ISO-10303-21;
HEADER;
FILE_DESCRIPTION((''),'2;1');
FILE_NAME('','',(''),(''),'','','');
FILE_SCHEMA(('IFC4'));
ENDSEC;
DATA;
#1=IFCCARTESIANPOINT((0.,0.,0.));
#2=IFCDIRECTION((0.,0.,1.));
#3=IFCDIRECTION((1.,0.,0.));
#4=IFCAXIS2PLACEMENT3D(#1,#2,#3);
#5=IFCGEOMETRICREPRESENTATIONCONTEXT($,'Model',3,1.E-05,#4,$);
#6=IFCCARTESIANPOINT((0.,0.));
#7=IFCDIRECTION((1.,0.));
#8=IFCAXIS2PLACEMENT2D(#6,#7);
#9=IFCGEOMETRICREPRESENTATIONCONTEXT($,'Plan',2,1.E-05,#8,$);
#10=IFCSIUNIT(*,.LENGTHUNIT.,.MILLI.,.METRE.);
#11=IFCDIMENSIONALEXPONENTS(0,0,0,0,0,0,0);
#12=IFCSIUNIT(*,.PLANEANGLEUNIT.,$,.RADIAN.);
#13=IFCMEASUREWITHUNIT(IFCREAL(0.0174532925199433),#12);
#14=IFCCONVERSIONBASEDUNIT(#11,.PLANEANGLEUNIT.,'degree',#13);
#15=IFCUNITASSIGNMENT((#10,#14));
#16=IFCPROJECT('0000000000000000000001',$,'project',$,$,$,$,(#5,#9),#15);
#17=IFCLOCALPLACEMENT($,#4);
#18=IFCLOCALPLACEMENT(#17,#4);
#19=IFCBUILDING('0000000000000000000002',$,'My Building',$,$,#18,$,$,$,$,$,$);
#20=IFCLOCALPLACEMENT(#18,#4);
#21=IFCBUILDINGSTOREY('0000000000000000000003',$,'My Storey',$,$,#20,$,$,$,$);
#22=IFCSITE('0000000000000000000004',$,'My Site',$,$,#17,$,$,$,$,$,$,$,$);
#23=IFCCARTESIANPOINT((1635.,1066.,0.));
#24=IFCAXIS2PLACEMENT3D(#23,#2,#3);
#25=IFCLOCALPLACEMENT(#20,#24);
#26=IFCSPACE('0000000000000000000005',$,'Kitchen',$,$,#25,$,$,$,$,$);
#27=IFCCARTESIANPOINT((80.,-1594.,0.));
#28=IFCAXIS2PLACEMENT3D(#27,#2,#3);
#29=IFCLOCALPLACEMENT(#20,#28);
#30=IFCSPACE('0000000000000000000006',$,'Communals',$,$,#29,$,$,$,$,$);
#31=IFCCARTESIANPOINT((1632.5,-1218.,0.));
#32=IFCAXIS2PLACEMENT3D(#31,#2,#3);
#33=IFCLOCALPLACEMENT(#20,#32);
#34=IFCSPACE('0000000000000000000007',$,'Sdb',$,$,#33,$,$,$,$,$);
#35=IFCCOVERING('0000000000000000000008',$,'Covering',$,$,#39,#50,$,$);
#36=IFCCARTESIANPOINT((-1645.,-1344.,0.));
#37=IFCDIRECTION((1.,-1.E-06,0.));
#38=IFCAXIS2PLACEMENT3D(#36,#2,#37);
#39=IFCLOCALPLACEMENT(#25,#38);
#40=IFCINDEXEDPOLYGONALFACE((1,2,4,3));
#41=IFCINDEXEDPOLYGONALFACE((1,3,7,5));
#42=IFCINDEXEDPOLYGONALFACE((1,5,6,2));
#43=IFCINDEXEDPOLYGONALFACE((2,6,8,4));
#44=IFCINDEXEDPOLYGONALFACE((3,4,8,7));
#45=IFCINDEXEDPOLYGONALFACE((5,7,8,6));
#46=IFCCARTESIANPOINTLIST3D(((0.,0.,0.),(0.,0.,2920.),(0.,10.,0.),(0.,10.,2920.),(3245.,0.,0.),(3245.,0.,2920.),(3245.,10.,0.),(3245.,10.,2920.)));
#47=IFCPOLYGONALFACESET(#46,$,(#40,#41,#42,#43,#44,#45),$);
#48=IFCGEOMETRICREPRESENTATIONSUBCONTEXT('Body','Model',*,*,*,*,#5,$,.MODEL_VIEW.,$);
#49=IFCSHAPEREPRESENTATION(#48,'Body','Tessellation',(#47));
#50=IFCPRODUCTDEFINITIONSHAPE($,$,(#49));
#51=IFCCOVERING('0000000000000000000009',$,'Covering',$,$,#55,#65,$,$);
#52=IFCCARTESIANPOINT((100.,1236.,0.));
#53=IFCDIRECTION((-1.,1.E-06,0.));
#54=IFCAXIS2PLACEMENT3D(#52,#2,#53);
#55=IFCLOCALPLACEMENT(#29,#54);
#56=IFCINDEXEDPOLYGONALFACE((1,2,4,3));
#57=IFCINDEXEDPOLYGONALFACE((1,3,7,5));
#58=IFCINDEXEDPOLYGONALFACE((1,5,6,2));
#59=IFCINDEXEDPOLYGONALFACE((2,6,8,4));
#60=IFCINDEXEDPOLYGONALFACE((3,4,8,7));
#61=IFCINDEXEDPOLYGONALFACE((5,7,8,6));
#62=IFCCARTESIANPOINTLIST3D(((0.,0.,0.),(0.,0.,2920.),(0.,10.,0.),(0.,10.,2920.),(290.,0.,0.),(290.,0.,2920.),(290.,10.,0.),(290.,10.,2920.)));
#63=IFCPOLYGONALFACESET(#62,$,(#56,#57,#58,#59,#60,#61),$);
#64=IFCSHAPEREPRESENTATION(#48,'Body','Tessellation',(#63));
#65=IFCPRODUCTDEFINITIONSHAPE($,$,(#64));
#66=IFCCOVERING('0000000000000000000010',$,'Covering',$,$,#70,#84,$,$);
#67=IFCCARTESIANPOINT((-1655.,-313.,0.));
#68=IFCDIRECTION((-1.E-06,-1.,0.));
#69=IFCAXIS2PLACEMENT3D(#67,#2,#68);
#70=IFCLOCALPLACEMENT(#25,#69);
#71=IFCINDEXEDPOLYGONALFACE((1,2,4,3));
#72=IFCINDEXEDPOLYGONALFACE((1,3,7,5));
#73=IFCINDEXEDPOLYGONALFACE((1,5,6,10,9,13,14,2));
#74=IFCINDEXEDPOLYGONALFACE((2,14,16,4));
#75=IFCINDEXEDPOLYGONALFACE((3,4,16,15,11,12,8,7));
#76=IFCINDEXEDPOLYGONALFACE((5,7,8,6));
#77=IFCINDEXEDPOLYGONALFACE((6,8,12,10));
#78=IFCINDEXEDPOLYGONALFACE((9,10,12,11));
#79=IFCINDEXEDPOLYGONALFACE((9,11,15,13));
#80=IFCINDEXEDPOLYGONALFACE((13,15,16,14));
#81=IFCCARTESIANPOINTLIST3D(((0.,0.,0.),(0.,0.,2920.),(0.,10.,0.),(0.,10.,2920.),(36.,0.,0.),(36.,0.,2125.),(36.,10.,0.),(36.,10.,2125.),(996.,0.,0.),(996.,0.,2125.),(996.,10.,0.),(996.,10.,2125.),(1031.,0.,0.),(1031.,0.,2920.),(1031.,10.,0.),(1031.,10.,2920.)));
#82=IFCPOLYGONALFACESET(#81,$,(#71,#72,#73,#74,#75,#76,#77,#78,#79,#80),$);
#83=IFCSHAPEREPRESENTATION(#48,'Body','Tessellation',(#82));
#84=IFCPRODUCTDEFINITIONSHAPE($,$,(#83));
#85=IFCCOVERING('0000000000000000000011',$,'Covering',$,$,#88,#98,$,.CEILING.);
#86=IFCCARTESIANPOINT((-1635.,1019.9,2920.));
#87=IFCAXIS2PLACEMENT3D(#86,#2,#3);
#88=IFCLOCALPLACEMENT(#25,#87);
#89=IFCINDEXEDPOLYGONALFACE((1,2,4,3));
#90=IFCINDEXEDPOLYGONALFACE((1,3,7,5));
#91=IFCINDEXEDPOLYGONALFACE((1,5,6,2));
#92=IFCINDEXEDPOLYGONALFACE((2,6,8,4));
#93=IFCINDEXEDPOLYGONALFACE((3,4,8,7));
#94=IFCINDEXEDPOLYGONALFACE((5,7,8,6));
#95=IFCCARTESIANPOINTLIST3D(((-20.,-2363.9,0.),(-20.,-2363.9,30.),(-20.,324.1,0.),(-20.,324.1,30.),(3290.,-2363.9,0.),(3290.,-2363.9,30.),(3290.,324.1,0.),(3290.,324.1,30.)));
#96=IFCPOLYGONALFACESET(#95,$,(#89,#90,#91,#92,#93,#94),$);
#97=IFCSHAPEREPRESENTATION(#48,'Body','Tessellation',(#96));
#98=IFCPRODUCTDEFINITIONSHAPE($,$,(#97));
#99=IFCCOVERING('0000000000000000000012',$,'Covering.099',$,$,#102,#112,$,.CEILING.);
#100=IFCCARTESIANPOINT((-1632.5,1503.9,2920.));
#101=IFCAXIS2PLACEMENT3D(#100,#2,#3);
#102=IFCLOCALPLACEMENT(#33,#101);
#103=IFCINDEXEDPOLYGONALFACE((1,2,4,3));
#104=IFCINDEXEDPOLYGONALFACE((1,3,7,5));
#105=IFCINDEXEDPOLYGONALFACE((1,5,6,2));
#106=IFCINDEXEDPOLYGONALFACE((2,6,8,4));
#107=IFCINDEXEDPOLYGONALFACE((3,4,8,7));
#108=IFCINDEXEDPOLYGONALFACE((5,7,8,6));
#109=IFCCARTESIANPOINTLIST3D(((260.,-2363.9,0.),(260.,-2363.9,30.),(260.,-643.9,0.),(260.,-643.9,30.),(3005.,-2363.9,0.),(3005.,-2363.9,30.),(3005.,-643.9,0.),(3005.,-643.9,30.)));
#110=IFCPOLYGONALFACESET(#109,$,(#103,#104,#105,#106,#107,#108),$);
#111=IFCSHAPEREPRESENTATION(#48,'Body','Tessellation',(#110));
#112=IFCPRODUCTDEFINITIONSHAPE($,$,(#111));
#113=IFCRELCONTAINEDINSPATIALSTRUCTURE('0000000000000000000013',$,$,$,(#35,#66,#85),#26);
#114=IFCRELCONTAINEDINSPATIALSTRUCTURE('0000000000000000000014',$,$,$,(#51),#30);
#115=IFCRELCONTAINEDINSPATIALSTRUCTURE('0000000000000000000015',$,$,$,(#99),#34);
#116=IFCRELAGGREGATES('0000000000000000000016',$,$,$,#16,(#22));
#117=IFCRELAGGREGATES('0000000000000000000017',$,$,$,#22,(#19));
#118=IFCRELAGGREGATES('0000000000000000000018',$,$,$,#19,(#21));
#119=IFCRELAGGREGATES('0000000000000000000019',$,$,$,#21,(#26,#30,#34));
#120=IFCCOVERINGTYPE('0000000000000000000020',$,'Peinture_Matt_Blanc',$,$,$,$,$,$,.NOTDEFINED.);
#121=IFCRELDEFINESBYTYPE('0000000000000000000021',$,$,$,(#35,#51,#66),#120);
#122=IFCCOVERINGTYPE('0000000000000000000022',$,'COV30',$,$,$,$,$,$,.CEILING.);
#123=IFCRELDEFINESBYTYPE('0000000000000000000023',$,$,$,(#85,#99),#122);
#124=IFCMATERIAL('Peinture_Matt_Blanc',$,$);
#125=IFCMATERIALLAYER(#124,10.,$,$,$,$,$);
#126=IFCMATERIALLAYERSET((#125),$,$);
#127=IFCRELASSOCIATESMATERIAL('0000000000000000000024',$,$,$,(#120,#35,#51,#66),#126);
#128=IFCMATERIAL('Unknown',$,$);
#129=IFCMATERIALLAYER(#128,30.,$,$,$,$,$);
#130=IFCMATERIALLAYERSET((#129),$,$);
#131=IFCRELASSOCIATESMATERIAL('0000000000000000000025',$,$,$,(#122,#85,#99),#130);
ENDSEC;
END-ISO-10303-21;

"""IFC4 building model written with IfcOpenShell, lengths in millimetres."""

from ifc_helpers import new_model, entity, si_unit, converted_unit, frame, origin_with_axes, origin_2d_with_axis, place, context, subcontext, project, spatial, line, indexed_curve, outline, extrude, clip, halfspace, source, transform, mapped, material, layer, layer_set, layer_usage, type_object, element, save


model = new_model("IFC4")

# Units and contexts
model_context = context("Model", 3, precision=1e-05, world=origin_with_axes())
plan_context = context("Plan", 2, precision=1e-05, world=origin_2d_with_axis())
body_context = subcontext(model_context, "Body", "Model", "MODEL_VIEW")
ifc_project = project(units=[si_unit("LENGTHUNIT", "METRE", prefix="MILLI"), converted_unit("PLANEANGLEUNIT", "degree", entity("IfcReal", 0.0174532925199433), si_unit("PLANEANGLEUNIT", "RADIAN"), dimensions=[0, 0, 0, 0, 0, 0, 0])], contexts=[model_context, plan_context])

# Site, building, storey
site_placement = place(None, origin_with_axes())
site = spatial("IfcSite", under=ifc_project, at=site_placement, Name="My Site")
building_placement = place(site_placement, origin_with_axes())
building = spatial("IfcBuilding", under=site, at=building_placement, Name="My Building")
storey_placement = place(building_placement, origin_with_axes())
storey = spatial("IfcBuildingStorey", under=building, at=storey_placement, Name="My Storey")

# Shared definitions
ifc_material_1 = material(Name="Unknown")

# Shared definitions
space_1_placement = place(storey_placement, frame((1635.0, 1066.0, 0.0), z_axis=(0.0, 0.0, 1.0), x_axis=(1.0, 0.0, 0.0)))
space_1 = spatial("IfcSpace", under=storey, at=space_1_placement, Name="Kitchen")

# Covering
ifc_material_2 = material(Name="Peinture_Matt_Blanc")
ifc_layer_1 = layer(ifc_material_2, 10.0)
ifc_layer_set_1 = layer_set([ifc_layer_1])
ifc_layer_usage_1 = layer_usage(ifc_layer_set_1, "AXIS2", "POSITIVE", 0.0)
covering_type_1 = type_object("IfcCoveringType", Name="Peinture_Matt_Blanc", PredefinedType="NOTDEFINED", material=ifc_layer_set_1)
covering_1_placement = place(space_1_placement, frame((-1645.0, -1344.0, 0.0), z_axis=(0.0, 0.0, 1.0), x_axis=(1.0, -0.000001, 0.0)))
element("IfcCovering", 1, at=covering_1_placement, inside=space_1, type_object=covering_type_1, material=ifc_layer_usage_1, Name="Covering", context=body_context, shape_type="Clipping", body=[
    clip(clip(extrude(outline(indexed_curve([(0.0, 0.0), (0.0, 10.0), (3245.0, 10.0), (3245.0, 0.0), (0.0, 0.0)], self_intersect=False)), origin_with_axes(), (0.0, 0.0, 1.0), 2920.0), halfspace(frame((0.0, 0.0, 2920.0), z_axis=(0.0, 0.0, 1.0), x_axis=(-1.0, 0.0, 0.0)), False)), halfspace(frame((0.0, 0.0, 2920.0), z_axis=(0.0, 0.0, 1.0), x_axis=(-1.0, 0.0, 0.0)), False)),
])

# Shared definitions
space_2_placement = place(storey_placement, frame((80.0, -1594.0, 0.0), z_axis=(0.0, 0.0, 1.0), x_axis=(1.0, 0.0, 0.0)))
space_2 = spatial("IfcSpace", under=storey, at=space_2_placement, Name="Communals")

# Covering
ifc_layer_usage_2 = layer_usage(ifc_layer_set_1, "AXIS2", "POSITIVE", 0.0)
covering_2_placement = place(space_2_placement, frame((100.0, 1236.0, 0.0), z_axis=(0.0, 0.0, 1.0), x_axis=(-1.0, 0.000001, 0.0)))
element("IfcCovering", 2, at=covering_2_placement, inside=space_2, type_object=covering_type_1, material=ifc_layer_usage_2, Name="Covering", context=body_context, shape_type="Clipping", body=[
    clip(clip(extrude(outline(indexed_curve([(0.0, 0.0), (0.0, 10.0), (290.0, 10.0), (290.0, 0.0), (0.0, 0.0)], self_intersect=False)), origin_with_axes(), (0.0, 0.0, 1.0), 2920.0), halfspace(frame((0.0, 0.0, 2920.0), z_axis=(0.0, 0.0, 1.0), x_axis=(-1.0, 0.0, 0.0)), False)), halfspace(frame((0.0, 0.0, 2920.0), z_axis=(0.0, 0.0, 1.0), x_axis=(-1.0, 0.0, 0.0)), False)),
])

# Covering, opening
ifc_layer_usage_3 = layer_usage(ifc_layer_set_1, "AXIS2", "POSITIVE", 0.0)
covering_3_placement = place(space_1_placement, frame((-1655.0, -313.0, 0.0), z_axis=(0.0, 0.0, 1.0), x_axis=(-0.000001, -1.0, 0.0)))
covering_3 = element("IfcCovering", 3, at=covering_3_placement, inside=space_1, type_object=covering_type_1, material=ifc_layer_usage_3, Name="Covering", context=body_context, shape_type="Clipping", body=[
    clip(clip(extrude(outline(indexed_curve([(0.0, 0.0), (0.0, 10.0), (1031.0, 10.0), (1031.0, 0.0), (0.0, 0.0)], self_intersect=False)), origin_with_axes(), (0.0, 0.0, 1.0), 2920.0), halfspace(frame((0.0, 0.0, 2920.0), z_axis=(0.0, 0.0, 1.0), x_axis=(-1.0, 0.0, 0.0)), False)), halfspace(frame((0.0, 0.0, 2920.0), z_axis=(0.0, 0.0, 1.0), x_axis=(-1.0, 0.0, 0.0)), False)),
])
shared_shape_1 = source(origin_with_axes(), body_context, "Body", "SweptSolid", [
    extrude(outline(indexed_curve([(0.0, 0.0), (960.0, 0.0), (960.0, 2125.0), (0.0, 2125.0)], segments=[line(4, 1), line(1, 2), line(2, 3), line(3, 4)], self_intersect=False)), frame((0.0, -600.0, 0.0), z_axis=(0.0, -1.0, 0.0), x_axis=(1.0, 0.0, 0.0)), (0.0, 0.0, -1.0), 1200.0),
])
opening_1_placement = place(covering_3_placement, frame((996.0, 0.0, 0.0), z_axis=(0.0, 0.0, 1.0), x_axis=(-1.0, 0.0, 0.0)))
element("IfcOpeningElement", 4, at=opening_1_placement, cuts=covering_3, PredefinedType="OPENING", context=body_context, shape_type="MappedRepresentation", body=[
    mapped(shared_shape_1, transform((0.0, 0.0, 0.0), x_axis=(1.0, 0.0, 0.0), y_axis=(0.0, 1.0, 0.0), z_axis=(0.0, 0.0, 1.0), scale=1.0)),
])

# Covering
ifc_layer_2 = layer(ifc_material_1, 30.0)
ifc_layer_set_2 = layer_set([ifc_layer_2])
ifc_layer_usage_4 = layer_usage(ifc_layer_set_2, "AXIS3", "POSITIVE", 0.0)
covering_type_2 = type_object("IfcCoveringType", Name="COV30", PredefinedType="CEILING", material=ifc_layer_set_2)
covering_4_placement = place(space_1_placement, frame((-1635.0, 1019.9, 2920.0), z_axis=(0.0, 0.0, 1.0), x_axis=(1.0, 0.0, 0.0)))
element("IfcCovering", 5, at=covering_4_placement, inside=space_1, type_object=covering_type_2, material=ifc_layer_usage_4, Name="Covering", PredefinedType="CEILING", context=body_context, shape_type="SweptSolid", body=[
    extrude(outline(indexed_curve([(-20.0, 324.1), (-20.0, -2363.9), (3290.0, -2363.9), (3290.0, 324.1)], segments=[line(3, 2), line(2, 1), line(1, 4), line(4, 3)], self_intersect=False)), None, (0.0, 0.0, 1.0), 30.0),
])

# Shared definitions
space_3_placement = place(storey_placement, frame((1632.5, -1218.0, 0.0), z_axis=(0.0, 0.0, 1.0), x_axis=(1.0, 0.0, 0.0)))
space_3 = spatial("IfcSpace", under=storey, at=space_3_placement, Name="Sdb")

# Covering
ifc_layer_usage_5 = layer_usage(ifc_layer_set_2, "AXIS3", "POSITIVE", 0.0)
covering_5_placement = place(space_3_placement, frame((-1632.5, 1503.9, 2920.0), z_axis=(0.0, 0.0, 1.0), x_axis=(1.0, 0.0, 0.0)))
element("IfcCovering", 6, at=covering_5_placement, inside=space_3, type_object=covering_type_2, material=ifc_layer_usage_5, Name="Covering.099", PredefinedType="CEILING", context=body_context, shape_type="SweptSolid", body=[
    extrude(outline(indexed_curve([(3005.0, -2363.9), (260.0, -2363.9), (260.0, -643.9), (3005.0, -643.9)], segments=[line(3, 2), line(2, 1), line(1, 4), line(4, 3)], self_intersect=False)), None, (0.0, 0.0, 1.0), 30.0),
])

save(model, "model.ifc")
